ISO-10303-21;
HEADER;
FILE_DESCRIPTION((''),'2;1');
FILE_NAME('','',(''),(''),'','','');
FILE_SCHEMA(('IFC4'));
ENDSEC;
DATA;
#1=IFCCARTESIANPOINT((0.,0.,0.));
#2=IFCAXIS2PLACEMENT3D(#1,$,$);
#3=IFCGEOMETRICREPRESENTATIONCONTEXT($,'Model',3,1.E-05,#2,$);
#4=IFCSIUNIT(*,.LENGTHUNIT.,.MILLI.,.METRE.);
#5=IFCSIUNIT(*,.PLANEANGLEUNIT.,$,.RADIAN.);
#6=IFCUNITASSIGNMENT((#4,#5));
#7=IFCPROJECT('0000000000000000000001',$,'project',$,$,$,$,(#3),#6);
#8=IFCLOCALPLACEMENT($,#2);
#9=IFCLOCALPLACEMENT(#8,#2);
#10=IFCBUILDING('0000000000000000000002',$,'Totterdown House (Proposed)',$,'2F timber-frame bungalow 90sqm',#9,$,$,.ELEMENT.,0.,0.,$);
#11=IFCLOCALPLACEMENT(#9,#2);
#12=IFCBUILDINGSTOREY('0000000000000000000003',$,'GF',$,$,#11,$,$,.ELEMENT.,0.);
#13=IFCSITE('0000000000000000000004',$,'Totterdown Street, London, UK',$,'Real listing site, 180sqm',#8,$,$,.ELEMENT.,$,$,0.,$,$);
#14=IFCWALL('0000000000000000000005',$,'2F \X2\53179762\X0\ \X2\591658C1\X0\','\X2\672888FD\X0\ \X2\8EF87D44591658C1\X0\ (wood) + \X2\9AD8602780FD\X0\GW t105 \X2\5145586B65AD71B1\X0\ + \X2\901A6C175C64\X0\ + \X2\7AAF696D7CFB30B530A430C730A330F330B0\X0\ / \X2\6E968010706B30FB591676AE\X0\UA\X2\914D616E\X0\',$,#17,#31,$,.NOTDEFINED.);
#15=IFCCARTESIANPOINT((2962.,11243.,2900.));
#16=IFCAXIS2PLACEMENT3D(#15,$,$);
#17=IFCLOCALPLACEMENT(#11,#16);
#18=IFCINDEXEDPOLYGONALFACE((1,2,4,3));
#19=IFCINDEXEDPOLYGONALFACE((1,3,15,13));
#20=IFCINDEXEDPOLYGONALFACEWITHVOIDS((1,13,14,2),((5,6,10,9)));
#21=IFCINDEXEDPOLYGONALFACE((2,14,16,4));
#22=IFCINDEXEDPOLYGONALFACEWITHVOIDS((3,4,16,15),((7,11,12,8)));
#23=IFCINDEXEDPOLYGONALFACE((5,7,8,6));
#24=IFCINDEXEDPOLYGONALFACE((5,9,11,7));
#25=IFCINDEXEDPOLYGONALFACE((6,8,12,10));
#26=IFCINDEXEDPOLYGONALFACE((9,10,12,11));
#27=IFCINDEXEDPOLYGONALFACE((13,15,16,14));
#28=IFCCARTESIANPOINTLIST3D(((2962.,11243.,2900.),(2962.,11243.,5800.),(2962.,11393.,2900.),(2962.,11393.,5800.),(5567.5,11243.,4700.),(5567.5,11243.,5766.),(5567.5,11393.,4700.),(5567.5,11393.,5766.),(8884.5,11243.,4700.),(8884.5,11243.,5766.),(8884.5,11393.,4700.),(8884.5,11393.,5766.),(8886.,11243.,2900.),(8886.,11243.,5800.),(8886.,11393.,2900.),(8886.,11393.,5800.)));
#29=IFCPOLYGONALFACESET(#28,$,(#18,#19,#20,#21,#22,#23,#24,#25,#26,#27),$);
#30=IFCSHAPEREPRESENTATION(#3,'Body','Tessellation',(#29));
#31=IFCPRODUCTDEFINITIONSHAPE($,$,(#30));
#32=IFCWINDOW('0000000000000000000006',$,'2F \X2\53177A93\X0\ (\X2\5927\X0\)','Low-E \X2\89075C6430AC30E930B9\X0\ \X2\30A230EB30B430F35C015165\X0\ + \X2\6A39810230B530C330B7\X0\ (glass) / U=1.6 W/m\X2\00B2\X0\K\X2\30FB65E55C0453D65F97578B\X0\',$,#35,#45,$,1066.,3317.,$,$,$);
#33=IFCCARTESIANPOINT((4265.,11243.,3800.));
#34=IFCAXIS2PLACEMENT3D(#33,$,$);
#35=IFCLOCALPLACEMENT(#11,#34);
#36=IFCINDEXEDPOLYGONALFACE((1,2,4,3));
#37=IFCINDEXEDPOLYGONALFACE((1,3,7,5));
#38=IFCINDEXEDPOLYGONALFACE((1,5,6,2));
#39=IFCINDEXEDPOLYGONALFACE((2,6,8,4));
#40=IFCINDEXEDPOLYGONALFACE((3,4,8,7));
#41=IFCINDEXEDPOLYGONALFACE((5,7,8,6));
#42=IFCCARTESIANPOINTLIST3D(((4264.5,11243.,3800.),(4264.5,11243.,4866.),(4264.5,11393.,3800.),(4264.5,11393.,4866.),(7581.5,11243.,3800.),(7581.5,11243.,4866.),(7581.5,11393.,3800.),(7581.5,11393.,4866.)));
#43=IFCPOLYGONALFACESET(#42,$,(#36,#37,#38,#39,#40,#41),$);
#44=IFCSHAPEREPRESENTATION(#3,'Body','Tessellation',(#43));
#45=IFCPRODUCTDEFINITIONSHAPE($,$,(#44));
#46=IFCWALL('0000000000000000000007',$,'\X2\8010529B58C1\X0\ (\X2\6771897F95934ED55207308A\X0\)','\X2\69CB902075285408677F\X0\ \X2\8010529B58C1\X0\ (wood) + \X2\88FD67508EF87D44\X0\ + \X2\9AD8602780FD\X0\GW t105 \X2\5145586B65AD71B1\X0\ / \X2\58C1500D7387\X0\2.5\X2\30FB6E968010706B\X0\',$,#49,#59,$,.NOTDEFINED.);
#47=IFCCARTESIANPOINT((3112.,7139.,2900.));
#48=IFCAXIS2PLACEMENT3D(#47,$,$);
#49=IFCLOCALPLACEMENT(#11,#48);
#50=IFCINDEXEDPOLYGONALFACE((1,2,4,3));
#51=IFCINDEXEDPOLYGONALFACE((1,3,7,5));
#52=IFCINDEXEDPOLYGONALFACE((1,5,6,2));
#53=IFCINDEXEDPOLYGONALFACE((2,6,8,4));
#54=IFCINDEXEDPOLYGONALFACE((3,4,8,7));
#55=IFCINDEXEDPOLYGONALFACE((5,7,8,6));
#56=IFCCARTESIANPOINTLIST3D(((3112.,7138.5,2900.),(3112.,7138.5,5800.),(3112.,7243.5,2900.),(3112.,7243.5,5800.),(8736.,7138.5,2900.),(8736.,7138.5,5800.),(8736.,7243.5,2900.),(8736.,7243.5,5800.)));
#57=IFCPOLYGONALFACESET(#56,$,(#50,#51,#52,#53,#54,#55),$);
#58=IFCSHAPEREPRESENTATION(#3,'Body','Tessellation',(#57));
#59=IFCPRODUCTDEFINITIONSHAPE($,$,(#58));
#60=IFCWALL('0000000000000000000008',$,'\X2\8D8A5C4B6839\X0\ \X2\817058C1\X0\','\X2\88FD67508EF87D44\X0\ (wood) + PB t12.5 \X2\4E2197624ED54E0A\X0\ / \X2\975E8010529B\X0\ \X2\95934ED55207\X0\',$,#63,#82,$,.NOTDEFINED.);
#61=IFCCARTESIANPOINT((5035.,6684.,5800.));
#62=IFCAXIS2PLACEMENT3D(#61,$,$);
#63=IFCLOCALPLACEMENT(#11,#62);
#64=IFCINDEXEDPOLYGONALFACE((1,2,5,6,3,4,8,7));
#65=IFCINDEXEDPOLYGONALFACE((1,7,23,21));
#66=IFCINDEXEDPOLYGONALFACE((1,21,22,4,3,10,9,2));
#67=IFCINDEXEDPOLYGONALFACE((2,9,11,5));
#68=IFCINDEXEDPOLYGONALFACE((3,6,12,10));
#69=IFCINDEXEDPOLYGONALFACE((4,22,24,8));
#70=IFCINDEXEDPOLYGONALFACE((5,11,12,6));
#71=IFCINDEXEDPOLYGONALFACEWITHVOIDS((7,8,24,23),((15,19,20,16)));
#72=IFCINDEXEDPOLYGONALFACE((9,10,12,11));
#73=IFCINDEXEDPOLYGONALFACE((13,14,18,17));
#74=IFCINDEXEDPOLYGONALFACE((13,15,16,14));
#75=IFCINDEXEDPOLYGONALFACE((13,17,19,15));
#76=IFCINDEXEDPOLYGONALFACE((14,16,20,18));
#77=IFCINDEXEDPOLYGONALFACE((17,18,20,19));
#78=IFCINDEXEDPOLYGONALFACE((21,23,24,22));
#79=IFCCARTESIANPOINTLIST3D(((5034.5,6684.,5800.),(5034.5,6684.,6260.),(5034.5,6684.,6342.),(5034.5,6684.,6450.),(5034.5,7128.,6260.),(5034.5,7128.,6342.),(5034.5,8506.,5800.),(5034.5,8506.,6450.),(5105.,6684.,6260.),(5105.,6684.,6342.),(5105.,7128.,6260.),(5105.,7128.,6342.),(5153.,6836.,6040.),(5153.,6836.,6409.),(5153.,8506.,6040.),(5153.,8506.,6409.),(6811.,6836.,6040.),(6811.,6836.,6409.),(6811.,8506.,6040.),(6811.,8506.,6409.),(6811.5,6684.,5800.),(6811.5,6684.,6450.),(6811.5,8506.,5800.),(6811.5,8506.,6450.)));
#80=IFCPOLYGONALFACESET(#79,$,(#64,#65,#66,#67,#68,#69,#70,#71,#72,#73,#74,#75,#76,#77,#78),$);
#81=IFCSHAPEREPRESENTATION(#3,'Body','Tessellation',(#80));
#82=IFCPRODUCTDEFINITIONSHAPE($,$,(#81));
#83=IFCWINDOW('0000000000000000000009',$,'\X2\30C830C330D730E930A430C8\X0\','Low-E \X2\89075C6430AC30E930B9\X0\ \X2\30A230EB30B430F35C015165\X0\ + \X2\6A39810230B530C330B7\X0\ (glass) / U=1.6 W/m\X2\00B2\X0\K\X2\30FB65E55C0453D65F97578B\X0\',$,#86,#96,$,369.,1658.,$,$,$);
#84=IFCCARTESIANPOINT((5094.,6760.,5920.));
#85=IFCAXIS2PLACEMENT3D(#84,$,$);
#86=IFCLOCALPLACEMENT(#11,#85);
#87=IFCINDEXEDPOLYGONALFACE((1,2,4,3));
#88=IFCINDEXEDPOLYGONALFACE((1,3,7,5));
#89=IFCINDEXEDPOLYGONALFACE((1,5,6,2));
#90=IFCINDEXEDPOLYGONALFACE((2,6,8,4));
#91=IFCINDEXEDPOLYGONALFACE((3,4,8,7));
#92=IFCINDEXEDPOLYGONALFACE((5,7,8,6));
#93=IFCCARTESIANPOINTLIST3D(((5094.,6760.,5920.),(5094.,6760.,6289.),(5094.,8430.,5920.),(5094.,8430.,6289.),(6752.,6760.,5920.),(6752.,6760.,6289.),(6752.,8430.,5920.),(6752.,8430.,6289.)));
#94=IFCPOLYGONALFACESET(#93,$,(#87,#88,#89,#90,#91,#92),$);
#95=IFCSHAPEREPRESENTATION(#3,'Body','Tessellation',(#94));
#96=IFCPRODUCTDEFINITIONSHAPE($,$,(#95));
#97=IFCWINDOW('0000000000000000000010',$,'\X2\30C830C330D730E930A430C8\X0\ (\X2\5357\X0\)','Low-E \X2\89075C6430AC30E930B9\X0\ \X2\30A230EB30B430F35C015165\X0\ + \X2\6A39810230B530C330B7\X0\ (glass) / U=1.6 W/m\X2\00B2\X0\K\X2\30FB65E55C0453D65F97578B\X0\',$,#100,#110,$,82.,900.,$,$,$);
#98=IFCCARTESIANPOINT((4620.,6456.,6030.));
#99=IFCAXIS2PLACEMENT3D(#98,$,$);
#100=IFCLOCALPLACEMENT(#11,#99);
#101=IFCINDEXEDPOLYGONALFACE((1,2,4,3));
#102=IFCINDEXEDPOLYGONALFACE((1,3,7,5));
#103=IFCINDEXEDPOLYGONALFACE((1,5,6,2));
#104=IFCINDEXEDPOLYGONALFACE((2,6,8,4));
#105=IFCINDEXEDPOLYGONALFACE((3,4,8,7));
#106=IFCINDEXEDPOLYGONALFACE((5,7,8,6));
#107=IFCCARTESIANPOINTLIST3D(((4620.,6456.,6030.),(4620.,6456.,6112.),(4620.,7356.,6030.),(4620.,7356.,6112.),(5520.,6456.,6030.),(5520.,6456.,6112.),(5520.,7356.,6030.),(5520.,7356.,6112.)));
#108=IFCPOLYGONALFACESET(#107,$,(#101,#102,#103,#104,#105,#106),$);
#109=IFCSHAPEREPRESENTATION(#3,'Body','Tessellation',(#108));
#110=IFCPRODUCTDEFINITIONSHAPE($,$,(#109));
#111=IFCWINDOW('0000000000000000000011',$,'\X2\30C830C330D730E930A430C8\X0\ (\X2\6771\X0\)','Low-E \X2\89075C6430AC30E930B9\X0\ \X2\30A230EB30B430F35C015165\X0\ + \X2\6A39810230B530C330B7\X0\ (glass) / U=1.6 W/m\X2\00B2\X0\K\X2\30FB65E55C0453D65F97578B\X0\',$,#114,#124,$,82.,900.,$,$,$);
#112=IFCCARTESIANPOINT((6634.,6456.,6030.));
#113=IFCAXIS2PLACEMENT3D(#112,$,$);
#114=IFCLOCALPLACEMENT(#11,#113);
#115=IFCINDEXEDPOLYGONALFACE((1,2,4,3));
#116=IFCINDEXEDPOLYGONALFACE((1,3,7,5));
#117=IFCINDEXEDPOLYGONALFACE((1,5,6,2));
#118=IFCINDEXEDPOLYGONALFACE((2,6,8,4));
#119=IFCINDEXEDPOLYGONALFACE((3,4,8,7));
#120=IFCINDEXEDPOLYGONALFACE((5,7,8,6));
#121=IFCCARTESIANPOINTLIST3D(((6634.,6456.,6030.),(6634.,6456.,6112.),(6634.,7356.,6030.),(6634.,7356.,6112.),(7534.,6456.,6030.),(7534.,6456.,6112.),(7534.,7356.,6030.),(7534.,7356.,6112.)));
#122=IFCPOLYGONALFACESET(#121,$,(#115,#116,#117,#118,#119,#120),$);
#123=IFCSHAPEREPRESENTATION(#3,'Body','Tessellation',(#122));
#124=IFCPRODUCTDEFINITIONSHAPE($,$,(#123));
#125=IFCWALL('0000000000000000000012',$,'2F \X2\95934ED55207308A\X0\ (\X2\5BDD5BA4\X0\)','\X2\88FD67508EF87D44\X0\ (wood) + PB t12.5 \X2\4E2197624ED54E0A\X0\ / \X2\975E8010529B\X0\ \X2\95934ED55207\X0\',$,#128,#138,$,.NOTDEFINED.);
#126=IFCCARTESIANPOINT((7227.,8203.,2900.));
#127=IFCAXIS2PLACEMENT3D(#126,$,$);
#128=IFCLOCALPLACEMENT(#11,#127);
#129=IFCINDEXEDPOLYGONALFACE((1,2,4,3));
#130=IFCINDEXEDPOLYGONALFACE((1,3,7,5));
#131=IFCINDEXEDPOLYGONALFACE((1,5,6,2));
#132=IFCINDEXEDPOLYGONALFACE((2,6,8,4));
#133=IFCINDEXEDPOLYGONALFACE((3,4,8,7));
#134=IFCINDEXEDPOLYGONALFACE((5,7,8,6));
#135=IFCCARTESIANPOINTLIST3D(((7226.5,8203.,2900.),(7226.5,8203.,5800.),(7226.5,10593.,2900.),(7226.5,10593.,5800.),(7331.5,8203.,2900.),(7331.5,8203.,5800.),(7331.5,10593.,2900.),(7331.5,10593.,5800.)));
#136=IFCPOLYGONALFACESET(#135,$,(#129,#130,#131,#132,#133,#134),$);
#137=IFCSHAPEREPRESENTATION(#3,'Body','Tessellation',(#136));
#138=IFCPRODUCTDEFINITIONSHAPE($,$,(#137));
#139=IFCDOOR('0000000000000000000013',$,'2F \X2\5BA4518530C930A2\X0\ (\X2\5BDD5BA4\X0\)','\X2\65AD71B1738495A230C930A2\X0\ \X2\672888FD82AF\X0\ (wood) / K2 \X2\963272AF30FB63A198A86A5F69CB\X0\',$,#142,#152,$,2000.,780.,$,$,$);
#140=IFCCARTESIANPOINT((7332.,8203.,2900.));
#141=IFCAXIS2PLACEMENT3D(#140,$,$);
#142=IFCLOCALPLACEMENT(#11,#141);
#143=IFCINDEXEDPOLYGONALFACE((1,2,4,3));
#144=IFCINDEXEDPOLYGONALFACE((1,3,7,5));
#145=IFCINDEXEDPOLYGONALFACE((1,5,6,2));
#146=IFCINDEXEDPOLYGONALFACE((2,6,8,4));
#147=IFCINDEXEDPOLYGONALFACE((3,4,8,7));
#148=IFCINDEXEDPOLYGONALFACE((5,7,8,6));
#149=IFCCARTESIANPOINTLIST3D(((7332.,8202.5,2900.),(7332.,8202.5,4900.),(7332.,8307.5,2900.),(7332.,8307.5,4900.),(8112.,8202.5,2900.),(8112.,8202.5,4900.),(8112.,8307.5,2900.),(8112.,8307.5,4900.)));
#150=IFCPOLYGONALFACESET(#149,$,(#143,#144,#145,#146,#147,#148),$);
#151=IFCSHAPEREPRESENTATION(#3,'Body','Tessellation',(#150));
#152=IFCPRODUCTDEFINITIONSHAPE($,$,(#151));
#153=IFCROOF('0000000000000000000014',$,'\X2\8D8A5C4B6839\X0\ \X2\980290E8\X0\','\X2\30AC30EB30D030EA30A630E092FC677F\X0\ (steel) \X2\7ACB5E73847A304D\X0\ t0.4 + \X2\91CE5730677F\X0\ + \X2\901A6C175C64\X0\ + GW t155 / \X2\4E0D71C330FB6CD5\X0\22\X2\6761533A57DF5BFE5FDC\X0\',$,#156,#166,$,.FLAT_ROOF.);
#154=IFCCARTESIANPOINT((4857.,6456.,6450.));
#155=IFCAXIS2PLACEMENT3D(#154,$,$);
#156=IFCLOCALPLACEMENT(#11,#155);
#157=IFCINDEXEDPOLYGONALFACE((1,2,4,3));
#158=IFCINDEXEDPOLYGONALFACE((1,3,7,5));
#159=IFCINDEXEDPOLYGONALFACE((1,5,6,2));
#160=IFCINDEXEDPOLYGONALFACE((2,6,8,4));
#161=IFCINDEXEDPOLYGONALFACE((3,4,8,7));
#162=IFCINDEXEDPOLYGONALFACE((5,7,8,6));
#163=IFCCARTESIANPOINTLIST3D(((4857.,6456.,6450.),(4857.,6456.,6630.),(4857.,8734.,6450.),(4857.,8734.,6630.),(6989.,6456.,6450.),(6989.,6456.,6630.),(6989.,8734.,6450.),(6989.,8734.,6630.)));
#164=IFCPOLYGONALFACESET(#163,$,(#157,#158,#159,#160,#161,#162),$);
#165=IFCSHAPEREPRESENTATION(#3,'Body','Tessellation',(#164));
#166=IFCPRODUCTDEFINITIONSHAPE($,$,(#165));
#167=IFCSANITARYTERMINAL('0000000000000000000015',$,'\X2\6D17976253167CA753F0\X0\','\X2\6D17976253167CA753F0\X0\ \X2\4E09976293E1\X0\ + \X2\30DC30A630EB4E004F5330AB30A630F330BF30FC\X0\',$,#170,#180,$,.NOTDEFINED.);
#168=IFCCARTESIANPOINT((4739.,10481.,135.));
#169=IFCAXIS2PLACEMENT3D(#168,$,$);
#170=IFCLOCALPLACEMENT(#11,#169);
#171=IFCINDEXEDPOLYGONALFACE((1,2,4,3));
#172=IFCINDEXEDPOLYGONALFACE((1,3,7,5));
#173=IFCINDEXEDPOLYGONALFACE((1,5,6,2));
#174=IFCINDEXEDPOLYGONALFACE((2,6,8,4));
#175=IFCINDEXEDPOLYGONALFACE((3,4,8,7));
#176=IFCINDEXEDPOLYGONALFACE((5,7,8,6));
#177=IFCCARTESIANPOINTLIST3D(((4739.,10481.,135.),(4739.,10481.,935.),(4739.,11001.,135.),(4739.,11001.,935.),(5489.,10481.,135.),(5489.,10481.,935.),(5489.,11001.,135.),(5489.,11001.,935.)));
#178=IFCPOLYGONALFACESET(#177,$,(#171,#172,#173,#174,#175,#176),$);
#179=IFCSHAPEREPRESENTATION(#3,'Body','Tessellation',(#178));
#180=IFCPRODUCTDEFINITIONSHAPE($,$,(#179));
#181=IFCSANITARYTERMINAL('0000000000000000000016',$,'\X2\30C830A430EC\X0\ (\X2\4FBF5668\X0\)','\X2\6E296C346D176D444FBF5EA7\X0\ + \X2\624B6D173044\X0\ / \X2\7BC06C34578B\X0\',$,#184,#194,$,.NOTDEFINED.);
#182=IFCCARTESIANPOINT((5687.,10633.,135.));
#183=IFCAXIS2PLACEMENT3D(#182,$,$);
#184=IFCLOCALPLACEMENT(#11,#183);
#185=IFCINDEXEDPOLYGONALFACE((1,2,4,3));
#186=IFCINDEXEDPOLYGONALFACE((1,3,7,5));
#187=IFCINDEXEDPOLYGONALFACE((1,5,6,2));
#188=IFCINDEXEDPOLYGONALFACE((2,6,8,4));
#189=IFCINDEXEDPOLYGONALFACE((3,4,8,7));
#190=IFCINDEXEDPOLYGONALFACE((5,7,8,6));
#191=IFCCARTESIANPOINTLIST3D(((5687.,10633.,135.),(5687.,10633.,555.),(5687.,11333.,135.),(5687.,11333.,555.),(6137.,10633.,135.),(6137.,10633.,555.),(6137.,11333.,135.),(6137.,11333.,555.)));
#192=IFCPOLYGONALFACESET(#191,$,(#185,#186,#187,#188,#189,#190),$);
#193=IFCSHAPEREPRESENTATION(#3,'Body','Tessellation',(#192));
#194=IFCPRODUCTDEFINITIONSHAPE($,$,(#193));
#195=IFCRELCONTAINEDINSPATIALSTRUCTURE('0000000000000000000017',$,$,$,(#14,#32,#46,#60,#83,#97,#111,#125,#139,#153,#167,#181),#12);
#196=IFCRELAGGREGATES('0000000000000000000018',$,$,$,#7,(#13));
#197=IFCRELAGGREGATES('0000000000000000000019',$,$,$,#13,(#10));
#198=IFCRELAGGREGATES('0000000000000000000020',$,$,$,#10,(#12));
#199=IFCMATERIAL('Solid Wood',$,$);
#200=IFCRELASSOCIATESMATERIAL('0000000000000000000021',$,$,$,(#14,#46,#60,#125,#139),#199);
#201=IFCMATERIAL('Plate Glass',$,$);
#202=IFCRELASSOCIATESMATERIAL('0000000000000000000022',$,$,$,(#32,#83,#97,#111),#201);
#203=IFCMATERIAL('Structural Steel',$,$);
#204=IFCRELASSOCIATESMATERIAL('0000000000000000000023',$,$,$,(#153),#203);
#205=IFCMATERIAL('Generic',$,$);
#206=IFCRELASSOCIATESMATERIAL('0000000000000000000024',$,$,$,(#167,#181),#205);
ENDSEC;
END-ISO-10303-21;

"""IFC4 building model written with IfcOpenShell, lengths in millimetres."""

from ifc_helpers import new_model, si_unit, frame, frame_2d, origin, place, context, project, spatial, rectangle, extrude, material, element, fill, save


model = new_model("IFC4")

# Units and contexts
model_context = context("Model", 3, precision=1e-05, world=origin())
ifc_project = project(units=[si_unit("LENGTHUNIT", "METRE", prefix="MILLI"), si_unit("PLANEANGLEUNIT", "RADIAN")], contexts=[model_context])

# Site, building, storey
site_placement = place(None, origin())
site = spatial("IfcSite", under=ifc_project, at=site_placement, Name="Totterdown Street, London, UK", ObjectType="Real listing site, 180sqm", CompositionType="ELEMENT", RefElevation=0.0)
building_placement = place(site_placement, origin())
building = spatial("IfcBuilding", under=site, at=building_placement, Name="Totterdown House (Proposed)", ObjectType="2F timber-frame bungalow 90sqm", CompositionType="ELEMENT", ElevationOfRefHeight=0.0, ElevationOfTerrain=0.0)
storey_placement = place(building_placement, origin())
storey = spatial("IfcBuildingStorey", under=building, at=storey_placement, Name="GF", CompositionType="ELEMENT", Elevation=0.0)

# Wall, opening, window
ifc_material_1 = material(Name="Solid Wood")
wall_1_placement = place(storey_placement, frame((2962.0, 11243.0, 2900.0)))
wall_1 = element("IfcWall", 1, at=wall_1_placement, inside=storey, material=ifc_material_1, Name="2F 北面 外壁", Description="木製 軸組外壁 (wood) + 高性能GW t105 充填断熱 + 通気層 + 窯業系サイディング / 準耐火・外皮UA配慮", PredefinedType="NOTDEFINED", context=model_context, shape_type="SweptSolid", body=[
    extrude(rectangle(XDim=5924.0, YDim=150.0, at=frame_2d((2962.0, 75.0))), frame((2962.0, 11243.0, 2900.0)), (0.0, 0.0, 1.0), 2900.0),
])
opening_1_placement = place(storey_placement, frame((4265.0, 11243.0, 3800.0)))
opening_1 = element("IfcOpeningElement", 2, at=opening_1_placement, cuts=wall_1, PredefinedType="NOTDEFINED", context=model_context, shape_type="SweptSolid", body=[
    extrude(rectangle(XDim=3317.0, YDim=150.0, at=frame_2d((1658.0, 75.0))), frame((4265.0, 11243.0, 3800.0)), (0.0, 0.0, 1.0), 1066.0),
])
ifc_material_2 = material(Name="Plate Glass")
window_1_placement = place(storey_placement, frame((4265.0, 11243.0, 3800.0)))
window_1 = element("IfcWindow", 3, at=window_1_placement, inside=storey, material=ifc_material_2, Name="2F 北窓 (大)", Description="Low-E 複層ガラス アルゴン封入 + 樹脂サッシ (glass) / U=1.6 W/m²K・日射取得型", OverallHeight=1066.0, OverallWidth=3317.0, context=model_context, shape_type="SweptSolid", body=[
    extrude(rectangle(XDim=3317.0, YDim=150.0, at=frame_2d((1658.0, 75.0))), frame((4265.0, 11243.0, 3800.0)), (0.0, 0.0, 1.0), 1066.0),
])
fill(opening_1, window_1)

# Wall
wall_2_placement = place(storey_placement, frame((3112.0, 7139.0, 2900.0)))
element("IfcWall", 4, at=wall_2_placement, inside=storey, material=ifc_material_1, Name="耐力壁 (東西間仕切り)", Description="構造用合板 耐力壁 (wood) + 製材軸組 + 高性能GW t105 充填断熱 / 壁倍率2.5・準耐火", PredefinedType="NOTDEFINED", context=model_context, shape_type="SweptSolid", body=[
    extrude(rectangle(XDim=5624.0, YDim=105.0, at=frame_2d((2812.0, 52.0))), frame((3112.0, 7139.0, 2900.0)), (0.0, 0.0, 1.0), 2900.0),
])

# Wall, openings, windows
wall_3_placement = place(storey_placement, frame((5035.0, 6684.0, 5800.0)))
wall_3 = element("IfcWall", 5, at=wall_3_placement, inside=storey, material=ifc_material_1, Name="越屋根 腰壁", Description="製材軸組 (wood) + PB t12.5 両面仕上 / 非耐力 間仕切", PredefinedType="NOTDEFINED", context=model_context, shape_type="SweptSolid", body=[
    extrude(rectangle(XDim=1777.0, YDim=1822.0, at=frame_2d((888.0, 911.0))), frame((5035.0, 6684.0, 5800.0)), (0.0, 0.0, 1.0), 650.0),
])
opening_2_placement = place(storey_placement, frame((5094.0, 6760.0, 5920.0)))
opening_2 = element("IfcOpeningElement", 6, at=opening_2_placement, cuts=wall_3, PredefinedType="NOTDEFINED", context=model_context, shape_type="SweptSolid", body=[
    extrude(rectangle(XDim=1658.0, YDim=1670.0, at=frame_2d((829.0, 835.0))), frame((5094.0, 6760.0, 5920.0)), (0.0, 0.0, 1.0), 369.0),
])
opening_3_placement = place(storey_placement, frame((4620.0, 6456.0, 6030.0)))
opening_3 = element("IfcOpeningElement", 7, at=opening_3_placement, cuts=wall_3, PredefinedType="NOTDEFINED", context=model_context, shape_type="SweptSolid", body=[
    extrude(rectangle(XDim=900.0, YDim=900.0, at=frame_2d((450.0, 450.0))), frame((4620.0, 6456.0, 6030.0)), (0.0, 0.0, 1.0), 82.0),
])
opening_4_placement = place(storey_placement, frame((6634.0, 6456.0, 6030.0)))
opening_4 = element("IfcOpeningElement", 8, at=opening_4_placement, cuts=wall_3, PredefinedType="NOTDEFINED", context=model_context, shape_type="SweptSolid", body=[
    extrude(rectangle(XDim=900.0, YDim=900.0, at=frame_2d((450.0, 450.0))), frame((6634.0, 6456.0, 6030.0)), (0.0, 0.0, 1.0), 82.0),
])
window_2_placement = place(storey_placement, frame((5094.0, 6760.0, 5920.0)))
window_2 = element("IfcWindow", 9, at=window_2_placement, inside=storey, material=ifc_material_2, Name="トップライト", Description="Low-E 複層ガラス アルゴン封入 + 樹脂サッシ (glass) / U=1.6 W/m²K・日射取得型", OverallHeight=369.0, OverallWidth=1658.0, context=model_context, shape_type="SweptSolid", body=[
    extrude(rectangle(XDim=1658.0, YDim=1670.0, at=frame_2d((829.0, 835.0))), frame((5094.0, 6760.0, 5920.0)), (0.0, 0.0, 1.0), 369.0),
])
fill(opening_2, window_2)
window_3_placement = place(storey_placement, frame((4620.0, 6456.0, 6030.0)))
window_3 = element("IfcWindow", 10, at=window_3_placement, inside=storey, material=ifc_material_2, Name="トップライト (南)", Description="Low-E 複層ガラス アルゴン封入 + 樹脂サッシ (glass) / U=1.6 W/m²K・日射取得型", OverallHeight=82.0, OverallWidth=900.0, context=model_context, shape_type="SweptSolid", body=[
    extrude(rectangle(XDim=900.0, YDim=900.0, at=frame_2d((450.0, 450.0))), frame((4620.0, 6456.0, 6030.0)), (0.0, 0.0, 1.0), 82.0),
])
fill(opening_3, window_3)
window_4_placement = place(storey_placement, frame((6634.0, 6456.0, 6030.0)))
window_4 = element("IfcWindow", 11, at=window_4_placement, inside=storey, material=ifc_material_2, Name="トップライト (東)", Description="Low-E 複層ガラス アルゴン封入 + 樹脂サッシ (glass) / U=1.6 W/m²K・日射取得型", OverallHeight=82.0, OverallWidth=900.0, context=model_context, shape_type="SweptSolid", body=[
    extrude(rectangle(XDim=900.0, YDim=900.0, at=frame_2d((450.0, 450.0))), frame((6634.0, 6456.0, 6030.0)), (0.0, 0.0, 1.0), 82.0),
])
fill(opening_4, window_4)

# Wall
wall_4_placement = place(storey_placement, frame((7227.0, 8203.0, 2900.0)))
element("IfcWall", 12, at=wall_4_placement, inside=storey, material=ifc_material_1, Name="2F 間仕切り (寝室)", Description="製材軸組 (wood) + PB t12.5 両面仕上 / 非耐力 間仕切", PredefinedType="NOTDEFINED", context=model_context, shape_type="SweptSolid", body=[
    extrude(rectangle(XDim=105.0, YDim=2390.0, at=frame_2d((52.0, 1195.0))), frame((7227.0, 8203.0, 2900.0)), (0.0, 0.0, 1.0), 2900.0),
])

# Door
door_placement = place(storey_placement, frame((7332.0, 8203.0, 2900.0)))
element("IfcDoor", 13, at=door_placement, inside=storey, material=ifc_material_1, Name="2F 室内ドア (寝室)", Description="断熱玄関ドア 木製芯 (wood) / K2 防犯・採風機構", OverallHeight=2000.0, OverallWidth=780.0, context=model_context, shape_type="SweptSolid", body=[
    extrude(rectangle(XDim=780.0, YDim=105.0, at=frame_2d((390.0, 52.0))), frame((7332.0, 8203.0, 2900.0)), (0.0, 0.0, 1.0), 2000.0),
])

# Roof
ifc_material_3 = material(Name="Structural Steel")
roof_placement = place(storey_placement, frame((4857.0, 6456.0, 6450.0)))
element("IfcRoof", 14, at=roof_placement, inside=storey, material=ifc_material_3, Name="越屋根 頂部", Description="ガルバリウム鋼板 (steel) 立平葺き t0.4 + 野地板 + 通気層 + GW t155 / 不燃・法22条区域対応", PredefinedType="FLAT_ROOF", context=model_context, shape_type="SweptSolid", body=[
    extrude(rectangle(XDim=2132.0, YDim=2278.0, at=frame_2d((1066.0, 1139.0))), frame((4857.0, 6456.0, 6450.0)), (0.0, 0.0, 1.0), 180.0),
])

# Sanitary terminals
ifc_material_4 = material(Name="Generic")
sanitary_terminal_1_placement = place(storey_placement, frame((4739.0, 10481.0, 135.0)))
element("IfcSanitaryTerminal", 15, at=sanitary_terminal_1_placement, inside=storey, material=ifc_material_4, Name="洗面化粧台", Description="洗面化粧台 三面鏡 + ボウル一体カウンター", PredefinedType="NOTDEFINED", context=model_context, shape_type="SweptSolid", body=[
    extrude(rectangle(XDim=750.0, YDim=520.0, at=frame_2d((375.0, 260.0))), frame((4739.0, 10481.0, 135.0)), (0.0, 0.0, 1.0), 800.0),
])
sanitary_terminal_2_placement = place(storey_placement, frame((5687.0, 10633.0, 135.0)))
element("IfcSanitaryTerminal", 16, at=sanitary_terminal_2_placement, inside=storey, material=ifc_material_4, Name="トイレ (便器)", Description="温水洗浄便座 + 手洗い / 節水型", PredefinedType="NOTDEFINED", context=model_context, shape_type="SweptSolid", body=[
    extrude(rectangle(XDim=450.0, YDim=700.0, at=frame_2d((225.0, 350.0))), frame((5687.0, 10633.0, 135.0)), (0.0, 0.0, 1.0), 420.0),
])

save(model, "model.ifc")
